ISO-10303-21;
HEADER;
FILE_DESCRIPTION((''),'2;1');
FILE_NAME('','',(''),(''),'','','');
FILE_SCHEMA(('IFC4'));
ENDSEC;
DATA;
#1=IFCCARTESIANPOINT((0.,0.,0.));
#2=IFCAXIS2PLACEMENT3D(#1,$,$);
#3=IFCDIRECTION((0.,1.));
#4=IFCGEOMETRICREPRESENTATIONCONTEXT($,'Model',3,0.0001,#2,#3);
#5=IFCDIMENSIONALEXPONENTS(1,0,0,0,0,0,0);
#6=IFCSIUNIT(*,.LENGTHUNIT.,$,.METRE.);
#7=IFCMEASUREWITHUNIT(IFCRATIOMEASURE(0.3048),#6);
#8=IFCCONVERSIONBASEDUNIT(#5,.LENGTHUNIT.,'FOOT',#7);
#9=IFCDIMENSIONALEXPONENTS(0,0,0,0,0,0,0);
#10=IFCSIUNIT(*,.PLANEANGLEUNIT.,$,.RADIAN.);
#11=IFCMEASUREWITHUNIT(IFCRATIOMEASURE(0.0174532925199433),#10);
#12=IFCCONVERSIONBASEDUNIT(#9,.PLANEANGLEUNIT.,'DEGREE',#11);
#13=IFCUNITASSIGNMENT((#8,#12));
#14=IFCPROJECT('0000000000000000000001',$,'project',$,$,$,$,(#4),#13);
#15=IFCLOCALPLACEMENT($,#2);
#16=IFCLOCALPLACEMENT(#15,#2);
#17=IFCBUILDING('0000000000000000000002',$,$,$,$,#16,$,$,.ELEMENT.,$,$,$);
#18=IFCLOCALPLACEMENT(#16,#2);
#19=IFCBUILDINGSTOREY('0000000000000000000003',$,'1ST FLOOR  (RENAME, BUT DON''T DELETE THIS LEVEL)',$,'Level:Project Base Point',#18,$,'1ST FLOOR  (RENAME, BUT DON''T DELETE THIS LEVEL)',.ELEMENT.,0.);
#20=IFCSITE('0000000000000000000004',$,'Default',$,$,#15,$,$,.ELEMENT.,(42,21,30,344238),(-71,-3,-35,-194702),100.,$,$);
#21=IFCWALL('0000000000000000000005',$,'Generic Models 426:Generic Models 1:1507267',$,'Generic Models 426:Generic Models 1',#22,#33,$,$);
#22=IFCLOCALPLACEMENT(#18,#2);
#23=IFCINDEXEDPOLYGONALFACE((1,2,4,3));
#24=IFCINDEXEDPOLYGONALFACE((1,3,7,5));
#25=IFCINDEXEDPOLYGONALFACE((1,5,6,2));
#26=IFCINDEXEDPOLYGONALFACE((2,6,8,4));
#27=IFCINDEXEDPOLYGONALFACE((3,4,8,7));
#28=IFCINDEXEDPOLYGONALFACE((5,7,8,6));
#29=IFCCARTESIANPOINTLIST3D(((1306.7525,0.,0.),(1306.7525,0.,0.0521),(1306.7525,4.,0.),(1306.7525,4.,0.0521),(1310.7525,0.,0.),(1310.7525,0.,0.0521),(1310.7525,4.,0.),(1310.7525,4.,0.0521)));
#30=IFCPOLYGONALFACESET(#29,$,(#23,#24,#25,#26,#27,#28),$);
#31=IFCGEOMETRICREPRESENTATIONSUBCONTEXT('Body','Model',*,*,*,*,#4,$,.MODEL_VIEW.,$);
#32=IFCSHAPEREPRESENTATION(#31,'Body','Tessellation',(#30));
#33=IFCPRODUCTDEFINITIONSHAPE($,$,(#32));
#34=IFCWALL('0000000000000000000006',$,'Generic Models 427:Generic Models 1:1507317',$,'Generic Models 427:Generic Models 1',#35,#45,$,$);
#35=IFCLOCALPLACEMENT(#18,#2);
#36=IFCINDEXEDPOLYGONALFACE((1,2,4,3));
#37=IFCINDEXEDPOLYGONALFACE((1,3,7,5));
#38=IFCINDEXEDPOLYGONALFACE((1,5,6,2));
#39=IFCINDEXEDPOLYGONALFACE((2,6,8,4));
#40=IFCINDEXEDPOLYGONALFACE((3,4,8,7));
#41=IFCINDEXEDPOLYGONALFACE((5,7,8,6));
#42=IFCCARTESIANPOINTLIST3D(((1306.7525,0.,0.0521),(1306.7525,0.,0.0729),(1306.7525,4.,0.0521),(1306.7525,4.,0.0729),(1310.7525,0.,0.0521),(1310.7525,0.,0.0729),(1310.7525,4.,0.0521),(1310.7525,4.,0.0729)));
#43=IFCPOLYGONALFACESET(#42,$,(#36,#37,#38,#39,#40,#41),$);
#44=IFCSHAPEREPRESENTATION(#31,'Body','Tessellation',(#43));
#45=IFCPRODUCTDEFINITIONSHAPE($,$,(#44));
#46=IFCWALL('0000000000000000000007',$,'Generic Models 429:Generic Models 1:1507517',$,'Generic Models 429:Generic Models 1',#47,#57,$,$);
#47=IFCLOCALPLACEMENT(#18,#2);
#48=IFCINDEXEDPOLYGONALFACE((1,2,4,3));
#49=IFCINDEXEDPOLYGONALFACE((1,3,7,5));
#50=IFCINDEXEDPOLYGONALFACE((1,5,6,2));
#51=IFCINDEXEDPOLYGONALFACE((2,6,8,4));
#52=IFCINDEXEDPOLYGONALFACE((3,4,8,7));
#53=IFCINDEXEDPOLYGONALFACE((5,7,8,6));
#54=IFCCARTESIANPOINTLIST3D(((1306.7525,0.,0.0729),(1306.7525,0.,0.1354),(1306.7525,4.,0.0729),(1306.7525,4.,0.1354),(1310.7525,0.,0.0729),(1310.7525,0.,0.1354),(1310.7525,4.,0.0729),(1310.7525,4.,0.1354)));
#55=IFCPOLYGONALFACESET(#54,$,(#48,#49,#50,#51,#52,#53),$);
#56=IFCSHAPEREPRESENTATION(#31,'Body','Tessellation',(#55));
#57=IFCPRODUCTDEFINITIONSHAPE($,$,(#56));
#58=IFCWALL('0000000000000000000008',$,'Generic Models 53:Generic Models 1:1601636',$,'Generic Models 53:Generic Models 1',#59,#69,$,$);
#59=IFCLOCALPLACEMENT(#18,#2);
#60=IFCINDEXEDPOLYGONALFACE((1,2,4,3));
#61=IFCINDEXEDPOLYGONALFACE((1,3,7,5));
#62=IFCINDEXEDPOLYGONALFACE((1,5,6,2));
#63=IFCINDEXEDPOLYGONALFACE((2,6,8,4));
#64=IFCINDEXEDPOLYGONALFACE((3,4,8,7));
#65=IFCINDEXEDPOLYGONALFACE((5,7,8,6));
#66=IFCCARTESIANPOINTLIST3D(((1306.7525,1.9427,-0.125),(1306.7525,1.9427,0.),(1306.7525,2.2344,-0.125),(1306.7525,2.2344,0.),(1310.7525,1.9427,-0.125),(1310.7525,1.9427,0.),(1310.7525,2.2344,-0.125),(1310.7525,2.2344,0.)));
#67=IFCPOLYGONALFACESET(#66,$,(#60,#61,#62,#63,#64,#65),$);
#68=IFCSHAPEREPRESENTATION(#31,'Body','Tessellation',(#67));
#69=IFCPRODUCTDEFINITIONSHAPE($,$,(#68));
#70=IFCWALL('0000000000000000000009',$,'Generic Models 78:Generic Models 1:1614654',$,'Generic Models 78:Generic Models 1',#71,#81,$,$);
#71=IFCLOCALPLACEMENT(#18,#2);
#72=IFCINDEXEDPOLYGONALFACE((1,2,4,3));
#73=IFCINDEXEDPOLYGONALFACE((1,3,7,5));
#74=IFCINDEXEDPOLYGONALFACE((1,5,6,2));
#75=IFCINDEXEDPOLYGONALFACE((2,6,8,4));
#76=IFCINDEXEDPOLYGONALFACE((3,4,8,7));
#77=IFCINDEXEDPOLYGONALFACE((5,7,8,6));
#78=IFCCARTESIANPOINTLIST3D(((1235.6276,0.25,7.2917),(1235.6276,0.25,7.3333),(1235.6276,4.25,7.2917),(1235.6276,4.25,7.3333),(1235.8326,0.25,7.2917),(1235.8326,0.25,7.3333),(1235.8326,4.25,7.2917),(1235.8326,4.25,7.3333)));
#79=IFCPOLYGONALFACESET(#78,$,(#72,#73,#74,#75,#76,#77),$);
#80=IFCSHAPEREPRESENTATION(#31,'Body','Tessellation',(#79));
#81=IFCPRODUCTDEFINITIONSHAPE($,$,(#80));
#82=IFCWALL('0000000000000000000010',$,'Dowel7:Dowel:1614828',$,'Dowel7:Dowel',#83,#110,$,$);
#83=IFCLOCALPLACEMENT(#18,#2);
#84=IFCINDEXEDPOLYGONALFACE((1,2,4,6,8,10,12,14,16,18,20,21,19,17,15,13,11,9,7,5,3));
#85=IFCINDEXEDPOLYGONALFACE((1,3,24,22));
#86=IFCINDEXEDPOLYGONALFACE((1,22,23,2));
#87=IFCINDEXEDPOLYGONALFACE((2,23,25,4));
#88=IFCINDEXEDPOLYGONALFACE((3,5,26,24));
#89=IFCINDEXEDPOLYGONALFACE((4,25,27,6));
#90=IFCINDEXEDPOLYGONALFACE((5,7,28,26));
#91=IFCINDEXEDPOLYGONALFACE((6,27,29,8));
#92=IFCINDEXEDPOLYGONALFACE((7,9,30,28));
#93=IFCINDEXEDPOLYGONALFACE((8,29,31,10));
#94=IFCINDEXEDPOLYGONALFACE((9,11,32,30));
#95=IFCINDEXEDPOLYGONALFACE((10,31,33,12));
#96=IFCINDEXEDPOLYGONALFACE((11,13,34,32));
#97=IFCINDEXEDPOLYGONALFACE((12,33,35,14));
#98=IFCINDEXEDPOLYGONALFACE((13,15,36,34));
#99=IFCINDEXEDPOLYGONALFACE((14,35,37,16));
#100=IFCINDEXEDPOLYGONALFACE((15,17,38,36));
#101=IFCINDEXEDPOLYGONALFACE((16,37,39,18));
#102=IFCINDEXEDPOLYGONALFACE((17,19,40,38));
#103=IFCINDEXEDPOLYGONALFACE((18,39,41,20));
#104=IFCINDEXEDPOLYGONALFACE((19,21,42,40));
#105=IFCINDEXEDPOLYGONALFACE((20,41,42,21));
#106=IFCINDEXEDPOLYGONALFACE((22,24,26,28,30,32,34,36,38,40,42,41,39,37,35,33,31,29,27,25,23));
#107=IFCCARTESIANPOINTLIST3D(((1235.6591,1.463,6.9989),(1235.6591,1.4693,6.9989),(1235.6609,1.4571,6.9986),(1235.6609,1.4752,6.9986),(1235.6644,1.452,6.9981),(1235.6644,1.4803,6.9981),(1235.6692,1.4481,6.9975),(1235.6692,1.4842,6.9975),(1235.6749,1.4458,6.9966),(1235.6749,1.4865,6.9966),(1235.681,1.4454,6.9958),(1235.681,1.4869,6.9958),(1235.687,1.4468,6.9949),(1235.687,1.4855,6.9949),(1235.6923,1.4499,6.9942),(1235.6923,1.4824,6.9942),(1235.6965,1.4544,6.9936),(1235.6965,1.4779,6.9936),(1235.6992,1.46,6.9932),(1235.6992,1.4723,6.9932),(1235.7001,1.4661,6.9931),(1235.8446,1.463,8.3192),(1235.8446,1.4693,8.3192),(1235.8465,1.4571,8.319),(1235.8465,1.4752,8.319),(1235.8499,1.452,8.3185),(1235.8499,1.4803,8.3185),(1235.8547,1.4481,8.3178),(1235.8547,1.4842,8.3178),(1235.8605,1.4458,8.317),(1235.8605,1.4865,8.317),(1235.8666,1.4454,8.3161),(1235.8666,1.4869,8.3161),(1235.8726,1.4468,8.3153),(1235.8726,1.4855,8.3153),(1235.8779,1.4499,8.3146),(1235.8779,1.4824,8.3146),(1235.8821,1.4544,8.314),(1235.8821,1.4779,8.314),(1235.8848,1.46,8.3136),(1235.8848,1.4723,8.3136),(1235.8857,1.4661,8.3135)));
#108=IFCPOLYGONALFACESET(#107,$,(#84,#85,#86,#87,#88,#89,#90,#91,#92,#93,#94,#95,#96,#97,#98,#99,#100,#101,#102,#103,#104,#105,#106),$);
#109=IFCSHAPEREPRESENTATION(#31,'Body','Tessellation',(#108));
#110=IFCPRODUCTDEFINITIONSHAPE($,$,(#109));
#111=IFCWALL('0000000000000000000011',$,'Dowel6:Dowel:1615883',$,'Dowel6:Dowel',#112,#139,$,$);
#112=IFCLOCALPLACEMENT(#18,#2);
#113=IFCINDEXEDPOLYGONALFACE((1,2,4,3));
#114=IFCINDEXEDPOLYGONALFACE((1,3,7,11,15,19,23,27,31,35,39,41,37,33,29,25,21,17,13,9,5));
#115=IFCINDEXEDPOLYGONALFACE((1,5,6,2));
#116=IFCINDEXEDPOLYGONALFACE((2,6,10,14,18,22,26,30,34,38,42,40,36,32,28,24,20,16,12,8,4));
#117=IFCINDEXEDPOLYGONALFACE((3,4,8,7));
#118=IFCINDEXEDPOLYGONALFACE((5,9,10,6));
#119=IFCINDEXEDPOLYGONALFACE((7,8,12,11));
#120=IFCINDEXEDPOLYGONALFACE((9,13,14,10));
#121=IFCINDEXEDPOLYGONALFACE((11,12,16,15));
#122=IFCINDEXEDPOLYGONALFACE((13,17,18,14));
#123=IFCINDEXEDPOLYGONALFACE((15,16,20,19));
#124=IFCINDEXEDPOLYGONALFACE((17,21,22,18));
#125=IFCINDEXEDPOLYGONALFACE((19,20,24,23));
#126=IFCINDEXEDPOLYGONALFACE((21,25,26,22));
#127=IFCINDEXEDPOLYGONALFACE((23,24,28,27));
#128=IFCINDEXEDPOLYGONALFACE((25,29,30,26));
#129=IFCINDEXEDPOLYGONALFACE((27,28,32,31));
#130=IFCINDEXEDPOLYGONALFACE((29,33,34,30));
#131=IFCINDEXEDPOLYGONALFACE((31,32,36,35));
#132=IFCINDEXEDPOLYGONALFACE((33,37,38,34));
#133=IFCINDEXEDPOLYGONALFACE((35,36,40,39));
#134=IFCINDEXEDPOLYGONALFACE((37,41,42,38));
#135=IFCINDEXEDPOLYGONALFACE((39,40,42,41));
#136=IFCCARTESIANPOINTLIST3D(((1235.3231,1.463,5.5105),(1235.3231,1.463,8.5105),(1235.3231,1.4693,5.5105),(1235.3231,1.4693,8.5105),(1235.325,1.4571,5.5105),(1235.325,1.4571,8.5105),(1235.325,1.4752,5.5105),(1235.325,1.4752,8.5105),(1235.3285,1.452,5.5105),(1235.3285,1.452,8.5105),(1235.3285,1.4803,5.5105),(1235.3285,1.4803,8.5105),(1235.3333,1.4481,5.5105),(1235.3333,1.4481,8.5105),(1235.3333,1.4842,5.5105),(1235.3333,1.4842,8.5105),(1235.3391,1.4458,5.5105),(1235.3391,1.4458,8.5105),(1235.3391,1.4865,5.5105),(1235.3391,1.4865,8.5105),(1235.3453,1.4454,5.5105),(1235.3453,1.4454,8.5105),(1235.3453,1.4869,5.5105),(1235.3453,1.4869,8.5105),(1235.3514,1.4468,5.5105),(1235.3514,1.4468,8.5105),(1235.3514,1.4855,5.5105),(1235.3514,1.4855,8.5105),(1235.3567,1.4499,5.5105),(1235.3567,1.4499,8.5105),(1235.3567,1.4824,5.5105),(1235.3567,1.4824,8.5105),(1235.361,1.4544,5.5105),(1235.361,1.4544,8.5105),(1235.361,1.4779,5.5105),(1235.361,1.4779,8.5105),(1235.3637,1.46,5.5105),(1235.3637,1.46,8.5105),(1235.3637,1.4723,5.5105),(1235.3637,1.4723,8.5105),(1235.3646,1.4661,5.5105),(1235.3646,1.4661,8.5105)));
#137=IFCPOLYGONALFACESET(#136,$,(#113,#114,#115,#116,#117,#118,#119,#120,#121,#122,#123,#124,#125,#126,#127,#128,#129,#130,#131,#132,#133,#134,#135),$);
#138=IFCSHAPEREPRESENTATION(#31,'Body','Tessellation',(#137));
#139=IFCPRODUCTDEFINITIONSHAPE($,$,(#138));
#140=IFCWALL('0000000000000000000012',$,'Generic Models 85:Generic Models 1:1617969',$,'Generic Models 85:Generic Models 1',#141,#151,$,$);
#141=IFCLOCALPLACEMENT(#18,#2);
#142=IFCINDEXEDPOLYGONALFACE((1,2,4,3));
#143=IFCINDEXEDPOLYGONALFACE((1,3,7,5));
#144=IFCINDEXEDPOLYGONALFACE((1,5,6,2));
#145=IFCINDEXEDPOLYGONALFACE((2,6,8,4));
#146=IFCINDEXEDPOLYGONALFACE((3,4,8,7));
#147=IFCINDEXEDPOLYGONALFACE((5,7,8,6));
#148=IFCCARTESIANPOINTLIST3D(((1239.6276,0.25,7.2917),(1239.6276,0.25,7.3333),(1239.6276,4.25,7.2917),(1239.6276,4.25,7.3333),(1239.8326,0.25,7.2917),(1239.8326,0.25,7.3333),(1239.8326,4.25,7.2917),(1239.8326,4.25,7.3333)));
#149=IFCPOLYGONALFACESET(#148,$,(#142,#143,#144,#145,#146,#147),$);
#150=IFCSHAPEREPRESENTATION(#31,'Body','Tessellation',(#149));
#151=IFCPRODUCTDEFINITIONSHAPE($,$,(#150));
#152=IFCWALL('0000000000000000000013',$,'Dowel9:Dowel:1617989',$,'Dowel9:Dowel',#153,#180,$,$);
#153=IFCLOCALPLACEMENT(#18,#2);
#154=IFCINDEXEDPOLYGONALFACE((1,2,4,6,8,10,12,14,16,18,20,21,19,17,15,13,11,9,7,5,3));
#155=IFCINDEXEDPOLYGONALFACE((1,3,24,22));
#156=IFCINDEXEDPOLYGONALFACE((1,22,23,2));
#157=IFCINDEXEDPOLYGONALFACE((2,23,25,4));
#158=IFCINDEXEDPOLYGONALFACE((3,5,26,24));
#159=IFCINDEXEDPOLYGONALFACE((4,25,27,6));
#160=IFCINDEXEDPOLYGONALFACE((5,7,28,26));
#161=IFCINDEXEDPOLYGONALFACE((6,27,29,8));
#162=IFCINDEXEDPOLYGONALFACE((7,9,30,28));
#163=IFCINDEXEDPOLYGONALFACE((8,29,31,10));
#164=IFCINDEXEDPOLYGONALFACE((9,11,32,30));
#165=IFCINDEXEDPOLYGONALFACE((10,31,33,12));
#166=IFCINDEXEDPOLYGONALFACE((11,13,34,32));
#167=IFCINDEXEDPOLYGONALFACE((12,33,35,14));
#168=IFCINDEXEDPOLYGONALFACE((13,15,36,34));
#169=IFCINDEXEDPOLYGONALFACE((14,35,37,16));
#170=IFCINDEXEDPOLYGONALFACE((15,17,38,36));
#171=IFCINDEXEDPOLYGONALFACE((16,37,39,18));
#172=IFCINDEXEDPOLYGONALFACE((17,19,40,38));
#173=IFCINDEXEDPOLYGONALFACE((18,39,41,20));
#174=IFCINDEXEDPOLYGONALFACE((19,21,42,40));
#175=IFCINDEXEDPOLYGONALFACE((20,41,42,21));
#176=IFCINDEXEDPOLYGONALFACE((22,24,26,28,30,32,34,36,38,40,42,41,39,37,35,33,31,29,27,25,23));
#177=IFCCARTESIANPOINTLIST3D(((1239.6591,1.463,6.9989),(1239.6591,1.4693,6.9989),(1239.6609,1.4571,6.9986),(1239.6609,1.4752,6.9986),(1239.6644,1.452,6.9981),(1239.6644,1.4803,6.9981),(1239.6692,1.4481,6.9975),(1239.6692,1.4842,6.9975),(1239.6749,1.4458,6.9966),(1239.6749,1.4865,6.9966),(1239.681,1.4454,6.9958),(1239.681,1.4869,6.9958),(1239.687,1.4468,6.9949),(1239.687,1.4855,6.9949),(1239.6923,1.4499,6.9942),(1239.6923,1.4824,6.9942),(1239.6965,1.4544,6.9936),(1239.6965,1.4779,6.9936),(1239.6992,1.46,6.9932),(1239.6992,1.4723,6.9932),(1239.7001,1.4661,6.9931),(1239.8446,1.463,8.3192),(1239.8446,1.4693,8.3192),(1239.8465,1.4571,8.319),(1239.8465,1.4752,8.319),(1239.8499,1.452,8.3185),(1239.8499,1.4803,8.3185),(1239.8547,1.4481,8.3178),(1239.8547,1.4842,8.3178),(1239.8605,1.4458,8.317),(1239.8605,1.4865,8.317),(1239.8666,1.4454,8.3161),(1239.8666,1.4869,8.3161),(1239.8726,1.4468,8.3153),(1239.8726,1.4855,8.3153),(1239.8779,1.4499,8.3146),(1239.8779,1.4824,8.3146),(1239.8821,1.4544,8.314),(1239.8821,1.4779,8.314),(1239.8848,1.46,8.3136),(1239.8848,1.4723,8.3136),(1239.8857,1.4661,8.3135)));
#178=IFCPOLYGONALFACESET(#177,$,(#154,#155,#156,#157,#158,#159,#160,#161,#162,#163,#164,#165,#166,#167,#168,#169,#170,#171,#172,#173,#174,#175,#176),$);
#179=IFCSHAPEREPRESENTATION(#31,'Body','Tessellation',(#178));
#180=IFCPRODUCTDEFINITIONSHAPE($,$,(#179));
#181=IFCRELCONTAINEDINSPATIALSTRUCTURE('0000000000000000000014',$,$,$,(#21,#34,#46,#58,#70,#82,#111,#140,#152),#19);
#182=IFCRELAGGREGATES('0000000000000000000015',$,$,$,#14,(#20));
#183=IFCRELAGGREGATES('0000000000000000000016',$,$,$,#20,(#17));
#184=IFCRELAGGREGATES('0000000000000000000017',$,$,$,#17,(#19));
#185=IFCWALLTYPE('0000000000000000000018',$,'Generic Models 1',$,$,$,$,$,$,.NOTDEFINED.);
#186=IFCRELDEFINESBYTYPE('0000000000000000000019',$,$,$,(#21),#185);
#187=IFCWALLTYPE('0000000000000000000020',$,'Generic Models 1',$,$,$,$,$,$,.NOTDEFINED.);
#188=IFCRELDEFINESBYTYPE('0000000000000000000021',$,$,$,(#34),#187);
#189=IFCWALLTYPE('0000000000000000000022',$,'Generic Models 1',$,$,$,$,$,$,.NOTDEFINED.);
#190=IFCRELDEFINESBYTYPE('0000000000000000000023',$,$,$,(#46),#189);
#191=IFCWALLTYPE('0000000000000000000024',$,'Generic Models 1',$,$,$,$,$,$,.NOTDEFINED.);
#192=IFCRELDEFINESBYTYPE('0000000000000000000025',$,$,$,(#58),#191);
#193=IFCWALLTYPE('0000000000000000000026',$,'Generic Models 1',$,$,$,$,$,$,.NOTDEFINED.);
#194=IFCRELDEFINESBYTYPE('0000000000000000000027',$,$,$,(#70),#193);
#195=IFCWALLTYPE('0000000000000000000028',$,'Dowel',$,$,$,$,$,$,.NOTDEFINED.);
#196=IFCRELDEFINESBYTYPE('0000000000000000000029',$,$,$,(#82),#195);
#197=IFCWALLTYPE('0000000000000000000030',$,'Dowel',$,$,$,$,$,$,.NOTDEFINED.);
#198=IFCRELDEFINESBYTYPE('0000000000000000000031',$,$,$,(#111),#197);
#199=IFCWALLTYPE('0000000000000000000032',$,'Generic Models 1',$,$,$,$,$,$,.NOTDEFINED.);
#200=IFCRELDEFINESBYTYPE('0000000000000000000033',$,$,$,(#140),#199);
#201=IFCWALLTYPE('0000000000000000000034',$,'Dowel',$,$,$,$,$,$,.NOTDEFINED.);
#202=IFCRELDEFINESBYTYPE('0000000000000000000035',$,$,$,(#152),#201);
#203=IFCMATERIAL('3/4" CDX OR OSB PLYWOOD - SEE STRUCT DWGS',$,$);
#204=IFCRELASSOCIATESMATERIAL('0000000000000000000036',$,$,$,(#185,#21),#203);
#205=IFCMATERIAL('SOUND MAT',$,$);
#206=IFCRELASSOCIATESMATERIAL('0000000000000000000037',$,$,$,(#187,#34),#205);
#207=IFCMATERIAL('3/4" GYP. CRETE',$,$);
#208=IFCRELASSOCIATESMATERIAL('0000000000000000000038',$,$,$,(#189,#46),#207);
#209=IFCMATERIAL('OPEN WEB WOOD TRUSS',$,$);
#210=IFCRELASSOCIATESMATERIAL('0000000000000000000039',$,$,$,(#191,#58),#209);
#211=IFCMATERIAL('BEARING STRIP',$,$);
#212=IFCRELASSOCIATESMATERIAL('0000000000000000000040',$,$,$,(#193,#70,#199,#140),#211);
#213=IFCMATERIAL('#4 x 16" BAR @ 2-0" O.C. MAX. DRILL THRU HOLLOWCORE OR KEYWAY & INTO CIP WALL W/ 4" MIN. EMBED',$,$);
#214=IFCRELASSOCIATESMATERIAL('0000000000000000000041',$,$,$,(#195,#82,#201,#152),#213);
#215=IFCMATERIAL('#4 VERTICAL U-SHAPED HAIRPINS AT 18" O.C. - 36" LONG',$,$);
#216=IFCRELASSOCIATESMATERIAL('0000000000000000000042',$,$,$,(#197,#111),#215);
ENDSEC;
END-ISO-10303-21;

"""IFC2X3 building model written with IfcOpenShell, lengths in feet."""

from ifc_helpers import new_model, entity, si_unit, converted_unit, direction, frame, frame_2d, origin, origin_2d_with_axis, place, context, subcontext, project, spatial, rectangle, circle, extrude, material, type_object, element, save


model = new_model("IFC2X3")

# Units and contexts
model_context = context("Model", 3, precision=0.0001, world=origin(), true_north=direction((0.0, 1.0)))
body_context = subcontext(model_context, "Body", "Model", "MODEL_VIEW")
ifc_project = project(units=[converted_unit("LENGTHUNIT", "FOOT", entity("IfcRatioMeasure", 0.3048), si_unit("LENGTHUNIT", "METRE"), dimensions=[1, 0, 0, 0, 0, 0, 0]), converted_unit("PLANEANGLEUNIT", "DEGREE", entity("IfcRatioMeasure", 0.0174532925199433), si_unit("PLANEANGLEUNIT", "RADIAN"), dimensions=[0, 0, 0, 0, 0, 0, 0])], contexts=[model_context])

# Site, building, storey
site_placement = place(None, origin())
site = spatial("IfcSite", under=ifc_project, at=site_placement, Name="Default", CompositionType="ELEMENT", RefLatitude=(42, 21, 30, 344238), RefLongitude=(-71, -3, -35, -194702), RefElevation=100.0)
building_placement = place(site_placement, origin())
building = spatial("IfcBuilding", under=site, at=building_placement, CompositionType="ELEMENT")
storey_placement = place(building_placement, origin())
storey = spatial("IfcBuildingStorey", under=building, at=storey_placement, Name="1ST FLOOR  (RENAME, BUT DON'T DELETE THIS LEVEL)", ObjectType="Level:Project Base Point", LongName="1ST FLOOR  (RENAME, BUT DON'T DELETE THIS LEVEL)", CompositionType="ELEMENT", Elevation=0.0)

# Walls
ifc_material_1 = material(Name="3/4\" CDX OR OSB PLYWOOD - SEE STRUCT DWGS")
wall_type_1 = type_object("IfcWallType", Name="Generic Models 1", PredefinedType="NOTDEFINED", material=ifc_material_1)
wall_1_placement = place(storey_placement, frame((1306.7525, 0.0, 0.0), z_axis=(0.0, 0.0, 1.0), x_axis=(0.0, 1.0, 0.0)))
element("IfcWall", 1, at=wall_1_placement, inside=storey, type_object=wall_type_1, material=ifc_material_1, Name="Generic Models 426:Generic Models 1:1507267", ObjectType="Generic Models 426:Generic Models 1", context=body_context, shape_type="SweptSolid", body=[
    extrude(rectangle(XDim=4.0, YDim=4.0, at=origin_2d_with_axis()), frame((2.0, -2.0, 0.0)), (0.0, 0.0, 1.0), 0.0521),
])
ifc_material_2 = material(Name="SOUND MAT")
wall_type_2 = type_object("IfcWallType", Name="Generic Models 1", PredefinedType="NOTDEFINED", material=ifc_material_2)
wall_2_placement = place(storey_placement, frame((1306.7525, 0.0, 0.0521), z_axis=(0.0, 0.0, 1.0), x_axis=(0.0, 1.0, 0.0)))
element("IfcWall", 2, at=wall_2_placement, inside=storey, type_object=wall_type_2, material=ifc_material_2, Name="Generic Models 427:Generic Models 1:1507317", ObjectType="Generic Models 427:Generic Models 1", context=body_context, shape_type="SweptSolid", body=[
    extrude(rectangle(XDim=4.0, YDim=4.0, at=origin_2d_with_axis()), frame((2.0, -2.0, 0.0)), (0.0, 0.0, 1.0), 0.0208),
])
ifc_material_3 = material(Name="3/4\" GYP. CRETE")
wall_type_3 = type_object("IfcWallType", Name="Generic Models 1", PredefinedType="NOTDEFINED", material=ifc_material_3)
wall_3_placement = place(storey_placement, frame((1306.7525, 0.0, 0.0729), z_axis=(0.0, 0.0, 1.0), x_axis=(0.0, 1.0, 0.0)))
element("IfcWall", 3, at=wall_3_placement, inside=storey, type_object=wall_type_3, material=ifc_material_3, Name="Generic Models 429:Generic Models 1:1507517", ObjectType="Generic Models 429:Generic Models 1", context=body_context, shape_type="SweptSolid", body=[
    extrude(rectangle(XDim=4.0, YDim=4.0, at=origin_2d_with_axis()), frame((2.0, -2.0, 0.0)), (0.0, 0.0, 1.0), 0.0625),
])
ifc_material_4 = material(Name="OPEN WEB WOOD TRUSS")
wall_type_4 = type_object("IfcWallType", Name="Generic Models 1", PredefinedType="NOTDEFINED", material=ifc_material_4)
wall_4_placement = place(storey_placement, frame((1306.7525, 1.9427, -0.125)))
element("IfcWall", 4, at=wall_4_placement, inside=storey, type_object=wall_type_4, material=ifc_material_4, Name="Generic Models 53:Generic Models 1:1601636", ObjectType="Generic Models 53:Generic Models 1", context=body_context, shape_type="SweptSolid", body=[
    extrude(rectangle(XDim=0.2917, YDim=4.0, at=frame_2d((0.0, 0.0), x_axis=(1.0, 0.0))), frame((2.0, 0.1458, 0.0), z_axis=(0.0, 0.0, 1.0), x_axis=(0.0, 1.0, 0.0)), (0.0, 0.0, 1.0), 0.125),
])
ifc_material_5 = material(Name="BEARING STRIP")
wall_type_5 = type_object("IfcWallType", Name="Generic Models 1", PredefinedType="NOTDEFINED", material=ifc_material_5)
wall_5_placement = place(storey_placement, frame((1235.6276, 0.25, 7.2917), z_axis=(0.0, 0.0, 1.0), x_axis=(0.0, 1.0, 0.0)))
element("IfcWall", 5, at=wall_5_placement, inside=storey, type_object=wall_type_5, material=ifc_material_5, Name="Generic Models 78:Generic Models 1:1614654", ObjectType="Generic Models 78:Generic Models 1", context=body_context, shape_type="SweptSolid", body=[
    extrude(rectangle(XDim=4.0, YDim=0.205, at=frame_2d((0.0, 0.0), x_axis=(1.0, 0.0))), frame((2.0, -0.1025, 0.0)), (0.0, 0.0, 1.0), 0.0417),
])
ifc_material_6 = material(Name="#4 x 16\" BAR @ 2-0\" O.C. MAX. DRILL THRU HOLLOWCORE OR KEYWAY & INTO CIP WALL W/ 4\" MIN. EMBED")
wall_type_6 = type_object("IfcWallType", Name="Dowel", PredefinedType="NOTDEFINED", material=ifc_material_6)
wall_6_placement = place(storey_placement, frame((1235.6589, 1.4453, 6.9931)))
element("IfcWall", 6, at=wall_6_placement, inside=storey, type_object=wall_type_6, material=ifc_material_6, Name="Dowel7:Dowel:1614828", ObjectType="Dowel7:Dowel", context=body_context, shape_type="SweptSolid", body=[
    extrude(circle(Radius=0.0208, at=frame_2d((0.0, 0.0), x_axis=(1.0, 0.0))), frame((0.0206, 0.0208, 0.0029), z_axis=(0.139173, 0.0, 0.990268), x_axis=(0.990268, 0.0, -0.139173)), (0.0, 0.0, 1.0), 1.3333),
])
ifc_material_7 = material(Name="#4 VERTICAL U-SHAPED HAIRPINS AT 18\" O.C. - 36\" LONG")
wall_type_7 = type_object("IfcWallType", Name="Dowel", PredefinedType="NOTDEFINED", material=ifc_material_7)
wall_7_placement = place(storey_placement, frame((1235.3229, 1.4453, 5.5105)))
element("IfcWall", 7, at=wall_7_placement, inside=storey, type_object=wall_type_7, material=ifc_material_7, Name="Dowel6:Dowel:1615883", ObjectType="Dowel6:Dowel", context=body_context, shape_type="SweptSolid", body=[
    extrude(circle(Radius=0.0208, at=frame_2d((0.0, 0.0), x_axis=(1.0, 0.0))), frame((0.0208, 0.0208, 0.0)), (0.0, 0.0, 1.0), 3.0),
])
wall_type_8 = type_object("IfcWallType", Name="Generic Models 1", PredefinedType="NOTDEFINED", material=ifc_material_5)
wall_8_placement = place(storey_placement, frame((1239.6276, 0.25, 7.2917), z_axis=(0.0, 0.0, 1.0), x_axis=(0.0, 1.0, 0.0)))
element("IfcWall", 8, at=wall_8_placement, inside=storey, type_object=wall_type_8, material=ifc_material_5, Name="Generic Models 85:Generic Models 1:1617969", ObjectType="Generic Models 85:Generic Models 1", context=body_context, shape_type="SweptSolid", body=[
    extrude(rectangle(XDim=4.0, YDim=0.205, at=frame_2d((0.0, 0.0), x_axis=(1.0, 0.0))), frame((2.0, -0.1025, 0.0)), (0.0, 0.0, 1.0), 0.0417),
])
wall_type_9 = type_object("IfcWallType", Name="Dowel", PredefinedType="NOTDEFINED", material=ifc_material_6)
wall_9_placement = place(storey_placement, frame((1239.6589, 1.4453, 6.9931)))
element("IfcWall", 9, at=wall_9_placement, inside=storey, type_object=wall_type_9, material=ifc_material_6, Name="Dowel9:Dowel:1617989", ObjectType="Dowel9:Dowel", context=body_context, shape_type="SweptSolid", body=[
    extrude(circle(Radius=0.0208, at=frame_2d((0.0, 0.0), x_axis=(1.0, 0.0))), frame((0.0206, 0.0208, 0.0029), z_axis=(0.139173, 0.0, 0.990268), x_axis=(0.990268, 0.0, -0.139173)), (0.0, 0.0, 1.0), 1.3333),
])

save(model, "model.ifc")
